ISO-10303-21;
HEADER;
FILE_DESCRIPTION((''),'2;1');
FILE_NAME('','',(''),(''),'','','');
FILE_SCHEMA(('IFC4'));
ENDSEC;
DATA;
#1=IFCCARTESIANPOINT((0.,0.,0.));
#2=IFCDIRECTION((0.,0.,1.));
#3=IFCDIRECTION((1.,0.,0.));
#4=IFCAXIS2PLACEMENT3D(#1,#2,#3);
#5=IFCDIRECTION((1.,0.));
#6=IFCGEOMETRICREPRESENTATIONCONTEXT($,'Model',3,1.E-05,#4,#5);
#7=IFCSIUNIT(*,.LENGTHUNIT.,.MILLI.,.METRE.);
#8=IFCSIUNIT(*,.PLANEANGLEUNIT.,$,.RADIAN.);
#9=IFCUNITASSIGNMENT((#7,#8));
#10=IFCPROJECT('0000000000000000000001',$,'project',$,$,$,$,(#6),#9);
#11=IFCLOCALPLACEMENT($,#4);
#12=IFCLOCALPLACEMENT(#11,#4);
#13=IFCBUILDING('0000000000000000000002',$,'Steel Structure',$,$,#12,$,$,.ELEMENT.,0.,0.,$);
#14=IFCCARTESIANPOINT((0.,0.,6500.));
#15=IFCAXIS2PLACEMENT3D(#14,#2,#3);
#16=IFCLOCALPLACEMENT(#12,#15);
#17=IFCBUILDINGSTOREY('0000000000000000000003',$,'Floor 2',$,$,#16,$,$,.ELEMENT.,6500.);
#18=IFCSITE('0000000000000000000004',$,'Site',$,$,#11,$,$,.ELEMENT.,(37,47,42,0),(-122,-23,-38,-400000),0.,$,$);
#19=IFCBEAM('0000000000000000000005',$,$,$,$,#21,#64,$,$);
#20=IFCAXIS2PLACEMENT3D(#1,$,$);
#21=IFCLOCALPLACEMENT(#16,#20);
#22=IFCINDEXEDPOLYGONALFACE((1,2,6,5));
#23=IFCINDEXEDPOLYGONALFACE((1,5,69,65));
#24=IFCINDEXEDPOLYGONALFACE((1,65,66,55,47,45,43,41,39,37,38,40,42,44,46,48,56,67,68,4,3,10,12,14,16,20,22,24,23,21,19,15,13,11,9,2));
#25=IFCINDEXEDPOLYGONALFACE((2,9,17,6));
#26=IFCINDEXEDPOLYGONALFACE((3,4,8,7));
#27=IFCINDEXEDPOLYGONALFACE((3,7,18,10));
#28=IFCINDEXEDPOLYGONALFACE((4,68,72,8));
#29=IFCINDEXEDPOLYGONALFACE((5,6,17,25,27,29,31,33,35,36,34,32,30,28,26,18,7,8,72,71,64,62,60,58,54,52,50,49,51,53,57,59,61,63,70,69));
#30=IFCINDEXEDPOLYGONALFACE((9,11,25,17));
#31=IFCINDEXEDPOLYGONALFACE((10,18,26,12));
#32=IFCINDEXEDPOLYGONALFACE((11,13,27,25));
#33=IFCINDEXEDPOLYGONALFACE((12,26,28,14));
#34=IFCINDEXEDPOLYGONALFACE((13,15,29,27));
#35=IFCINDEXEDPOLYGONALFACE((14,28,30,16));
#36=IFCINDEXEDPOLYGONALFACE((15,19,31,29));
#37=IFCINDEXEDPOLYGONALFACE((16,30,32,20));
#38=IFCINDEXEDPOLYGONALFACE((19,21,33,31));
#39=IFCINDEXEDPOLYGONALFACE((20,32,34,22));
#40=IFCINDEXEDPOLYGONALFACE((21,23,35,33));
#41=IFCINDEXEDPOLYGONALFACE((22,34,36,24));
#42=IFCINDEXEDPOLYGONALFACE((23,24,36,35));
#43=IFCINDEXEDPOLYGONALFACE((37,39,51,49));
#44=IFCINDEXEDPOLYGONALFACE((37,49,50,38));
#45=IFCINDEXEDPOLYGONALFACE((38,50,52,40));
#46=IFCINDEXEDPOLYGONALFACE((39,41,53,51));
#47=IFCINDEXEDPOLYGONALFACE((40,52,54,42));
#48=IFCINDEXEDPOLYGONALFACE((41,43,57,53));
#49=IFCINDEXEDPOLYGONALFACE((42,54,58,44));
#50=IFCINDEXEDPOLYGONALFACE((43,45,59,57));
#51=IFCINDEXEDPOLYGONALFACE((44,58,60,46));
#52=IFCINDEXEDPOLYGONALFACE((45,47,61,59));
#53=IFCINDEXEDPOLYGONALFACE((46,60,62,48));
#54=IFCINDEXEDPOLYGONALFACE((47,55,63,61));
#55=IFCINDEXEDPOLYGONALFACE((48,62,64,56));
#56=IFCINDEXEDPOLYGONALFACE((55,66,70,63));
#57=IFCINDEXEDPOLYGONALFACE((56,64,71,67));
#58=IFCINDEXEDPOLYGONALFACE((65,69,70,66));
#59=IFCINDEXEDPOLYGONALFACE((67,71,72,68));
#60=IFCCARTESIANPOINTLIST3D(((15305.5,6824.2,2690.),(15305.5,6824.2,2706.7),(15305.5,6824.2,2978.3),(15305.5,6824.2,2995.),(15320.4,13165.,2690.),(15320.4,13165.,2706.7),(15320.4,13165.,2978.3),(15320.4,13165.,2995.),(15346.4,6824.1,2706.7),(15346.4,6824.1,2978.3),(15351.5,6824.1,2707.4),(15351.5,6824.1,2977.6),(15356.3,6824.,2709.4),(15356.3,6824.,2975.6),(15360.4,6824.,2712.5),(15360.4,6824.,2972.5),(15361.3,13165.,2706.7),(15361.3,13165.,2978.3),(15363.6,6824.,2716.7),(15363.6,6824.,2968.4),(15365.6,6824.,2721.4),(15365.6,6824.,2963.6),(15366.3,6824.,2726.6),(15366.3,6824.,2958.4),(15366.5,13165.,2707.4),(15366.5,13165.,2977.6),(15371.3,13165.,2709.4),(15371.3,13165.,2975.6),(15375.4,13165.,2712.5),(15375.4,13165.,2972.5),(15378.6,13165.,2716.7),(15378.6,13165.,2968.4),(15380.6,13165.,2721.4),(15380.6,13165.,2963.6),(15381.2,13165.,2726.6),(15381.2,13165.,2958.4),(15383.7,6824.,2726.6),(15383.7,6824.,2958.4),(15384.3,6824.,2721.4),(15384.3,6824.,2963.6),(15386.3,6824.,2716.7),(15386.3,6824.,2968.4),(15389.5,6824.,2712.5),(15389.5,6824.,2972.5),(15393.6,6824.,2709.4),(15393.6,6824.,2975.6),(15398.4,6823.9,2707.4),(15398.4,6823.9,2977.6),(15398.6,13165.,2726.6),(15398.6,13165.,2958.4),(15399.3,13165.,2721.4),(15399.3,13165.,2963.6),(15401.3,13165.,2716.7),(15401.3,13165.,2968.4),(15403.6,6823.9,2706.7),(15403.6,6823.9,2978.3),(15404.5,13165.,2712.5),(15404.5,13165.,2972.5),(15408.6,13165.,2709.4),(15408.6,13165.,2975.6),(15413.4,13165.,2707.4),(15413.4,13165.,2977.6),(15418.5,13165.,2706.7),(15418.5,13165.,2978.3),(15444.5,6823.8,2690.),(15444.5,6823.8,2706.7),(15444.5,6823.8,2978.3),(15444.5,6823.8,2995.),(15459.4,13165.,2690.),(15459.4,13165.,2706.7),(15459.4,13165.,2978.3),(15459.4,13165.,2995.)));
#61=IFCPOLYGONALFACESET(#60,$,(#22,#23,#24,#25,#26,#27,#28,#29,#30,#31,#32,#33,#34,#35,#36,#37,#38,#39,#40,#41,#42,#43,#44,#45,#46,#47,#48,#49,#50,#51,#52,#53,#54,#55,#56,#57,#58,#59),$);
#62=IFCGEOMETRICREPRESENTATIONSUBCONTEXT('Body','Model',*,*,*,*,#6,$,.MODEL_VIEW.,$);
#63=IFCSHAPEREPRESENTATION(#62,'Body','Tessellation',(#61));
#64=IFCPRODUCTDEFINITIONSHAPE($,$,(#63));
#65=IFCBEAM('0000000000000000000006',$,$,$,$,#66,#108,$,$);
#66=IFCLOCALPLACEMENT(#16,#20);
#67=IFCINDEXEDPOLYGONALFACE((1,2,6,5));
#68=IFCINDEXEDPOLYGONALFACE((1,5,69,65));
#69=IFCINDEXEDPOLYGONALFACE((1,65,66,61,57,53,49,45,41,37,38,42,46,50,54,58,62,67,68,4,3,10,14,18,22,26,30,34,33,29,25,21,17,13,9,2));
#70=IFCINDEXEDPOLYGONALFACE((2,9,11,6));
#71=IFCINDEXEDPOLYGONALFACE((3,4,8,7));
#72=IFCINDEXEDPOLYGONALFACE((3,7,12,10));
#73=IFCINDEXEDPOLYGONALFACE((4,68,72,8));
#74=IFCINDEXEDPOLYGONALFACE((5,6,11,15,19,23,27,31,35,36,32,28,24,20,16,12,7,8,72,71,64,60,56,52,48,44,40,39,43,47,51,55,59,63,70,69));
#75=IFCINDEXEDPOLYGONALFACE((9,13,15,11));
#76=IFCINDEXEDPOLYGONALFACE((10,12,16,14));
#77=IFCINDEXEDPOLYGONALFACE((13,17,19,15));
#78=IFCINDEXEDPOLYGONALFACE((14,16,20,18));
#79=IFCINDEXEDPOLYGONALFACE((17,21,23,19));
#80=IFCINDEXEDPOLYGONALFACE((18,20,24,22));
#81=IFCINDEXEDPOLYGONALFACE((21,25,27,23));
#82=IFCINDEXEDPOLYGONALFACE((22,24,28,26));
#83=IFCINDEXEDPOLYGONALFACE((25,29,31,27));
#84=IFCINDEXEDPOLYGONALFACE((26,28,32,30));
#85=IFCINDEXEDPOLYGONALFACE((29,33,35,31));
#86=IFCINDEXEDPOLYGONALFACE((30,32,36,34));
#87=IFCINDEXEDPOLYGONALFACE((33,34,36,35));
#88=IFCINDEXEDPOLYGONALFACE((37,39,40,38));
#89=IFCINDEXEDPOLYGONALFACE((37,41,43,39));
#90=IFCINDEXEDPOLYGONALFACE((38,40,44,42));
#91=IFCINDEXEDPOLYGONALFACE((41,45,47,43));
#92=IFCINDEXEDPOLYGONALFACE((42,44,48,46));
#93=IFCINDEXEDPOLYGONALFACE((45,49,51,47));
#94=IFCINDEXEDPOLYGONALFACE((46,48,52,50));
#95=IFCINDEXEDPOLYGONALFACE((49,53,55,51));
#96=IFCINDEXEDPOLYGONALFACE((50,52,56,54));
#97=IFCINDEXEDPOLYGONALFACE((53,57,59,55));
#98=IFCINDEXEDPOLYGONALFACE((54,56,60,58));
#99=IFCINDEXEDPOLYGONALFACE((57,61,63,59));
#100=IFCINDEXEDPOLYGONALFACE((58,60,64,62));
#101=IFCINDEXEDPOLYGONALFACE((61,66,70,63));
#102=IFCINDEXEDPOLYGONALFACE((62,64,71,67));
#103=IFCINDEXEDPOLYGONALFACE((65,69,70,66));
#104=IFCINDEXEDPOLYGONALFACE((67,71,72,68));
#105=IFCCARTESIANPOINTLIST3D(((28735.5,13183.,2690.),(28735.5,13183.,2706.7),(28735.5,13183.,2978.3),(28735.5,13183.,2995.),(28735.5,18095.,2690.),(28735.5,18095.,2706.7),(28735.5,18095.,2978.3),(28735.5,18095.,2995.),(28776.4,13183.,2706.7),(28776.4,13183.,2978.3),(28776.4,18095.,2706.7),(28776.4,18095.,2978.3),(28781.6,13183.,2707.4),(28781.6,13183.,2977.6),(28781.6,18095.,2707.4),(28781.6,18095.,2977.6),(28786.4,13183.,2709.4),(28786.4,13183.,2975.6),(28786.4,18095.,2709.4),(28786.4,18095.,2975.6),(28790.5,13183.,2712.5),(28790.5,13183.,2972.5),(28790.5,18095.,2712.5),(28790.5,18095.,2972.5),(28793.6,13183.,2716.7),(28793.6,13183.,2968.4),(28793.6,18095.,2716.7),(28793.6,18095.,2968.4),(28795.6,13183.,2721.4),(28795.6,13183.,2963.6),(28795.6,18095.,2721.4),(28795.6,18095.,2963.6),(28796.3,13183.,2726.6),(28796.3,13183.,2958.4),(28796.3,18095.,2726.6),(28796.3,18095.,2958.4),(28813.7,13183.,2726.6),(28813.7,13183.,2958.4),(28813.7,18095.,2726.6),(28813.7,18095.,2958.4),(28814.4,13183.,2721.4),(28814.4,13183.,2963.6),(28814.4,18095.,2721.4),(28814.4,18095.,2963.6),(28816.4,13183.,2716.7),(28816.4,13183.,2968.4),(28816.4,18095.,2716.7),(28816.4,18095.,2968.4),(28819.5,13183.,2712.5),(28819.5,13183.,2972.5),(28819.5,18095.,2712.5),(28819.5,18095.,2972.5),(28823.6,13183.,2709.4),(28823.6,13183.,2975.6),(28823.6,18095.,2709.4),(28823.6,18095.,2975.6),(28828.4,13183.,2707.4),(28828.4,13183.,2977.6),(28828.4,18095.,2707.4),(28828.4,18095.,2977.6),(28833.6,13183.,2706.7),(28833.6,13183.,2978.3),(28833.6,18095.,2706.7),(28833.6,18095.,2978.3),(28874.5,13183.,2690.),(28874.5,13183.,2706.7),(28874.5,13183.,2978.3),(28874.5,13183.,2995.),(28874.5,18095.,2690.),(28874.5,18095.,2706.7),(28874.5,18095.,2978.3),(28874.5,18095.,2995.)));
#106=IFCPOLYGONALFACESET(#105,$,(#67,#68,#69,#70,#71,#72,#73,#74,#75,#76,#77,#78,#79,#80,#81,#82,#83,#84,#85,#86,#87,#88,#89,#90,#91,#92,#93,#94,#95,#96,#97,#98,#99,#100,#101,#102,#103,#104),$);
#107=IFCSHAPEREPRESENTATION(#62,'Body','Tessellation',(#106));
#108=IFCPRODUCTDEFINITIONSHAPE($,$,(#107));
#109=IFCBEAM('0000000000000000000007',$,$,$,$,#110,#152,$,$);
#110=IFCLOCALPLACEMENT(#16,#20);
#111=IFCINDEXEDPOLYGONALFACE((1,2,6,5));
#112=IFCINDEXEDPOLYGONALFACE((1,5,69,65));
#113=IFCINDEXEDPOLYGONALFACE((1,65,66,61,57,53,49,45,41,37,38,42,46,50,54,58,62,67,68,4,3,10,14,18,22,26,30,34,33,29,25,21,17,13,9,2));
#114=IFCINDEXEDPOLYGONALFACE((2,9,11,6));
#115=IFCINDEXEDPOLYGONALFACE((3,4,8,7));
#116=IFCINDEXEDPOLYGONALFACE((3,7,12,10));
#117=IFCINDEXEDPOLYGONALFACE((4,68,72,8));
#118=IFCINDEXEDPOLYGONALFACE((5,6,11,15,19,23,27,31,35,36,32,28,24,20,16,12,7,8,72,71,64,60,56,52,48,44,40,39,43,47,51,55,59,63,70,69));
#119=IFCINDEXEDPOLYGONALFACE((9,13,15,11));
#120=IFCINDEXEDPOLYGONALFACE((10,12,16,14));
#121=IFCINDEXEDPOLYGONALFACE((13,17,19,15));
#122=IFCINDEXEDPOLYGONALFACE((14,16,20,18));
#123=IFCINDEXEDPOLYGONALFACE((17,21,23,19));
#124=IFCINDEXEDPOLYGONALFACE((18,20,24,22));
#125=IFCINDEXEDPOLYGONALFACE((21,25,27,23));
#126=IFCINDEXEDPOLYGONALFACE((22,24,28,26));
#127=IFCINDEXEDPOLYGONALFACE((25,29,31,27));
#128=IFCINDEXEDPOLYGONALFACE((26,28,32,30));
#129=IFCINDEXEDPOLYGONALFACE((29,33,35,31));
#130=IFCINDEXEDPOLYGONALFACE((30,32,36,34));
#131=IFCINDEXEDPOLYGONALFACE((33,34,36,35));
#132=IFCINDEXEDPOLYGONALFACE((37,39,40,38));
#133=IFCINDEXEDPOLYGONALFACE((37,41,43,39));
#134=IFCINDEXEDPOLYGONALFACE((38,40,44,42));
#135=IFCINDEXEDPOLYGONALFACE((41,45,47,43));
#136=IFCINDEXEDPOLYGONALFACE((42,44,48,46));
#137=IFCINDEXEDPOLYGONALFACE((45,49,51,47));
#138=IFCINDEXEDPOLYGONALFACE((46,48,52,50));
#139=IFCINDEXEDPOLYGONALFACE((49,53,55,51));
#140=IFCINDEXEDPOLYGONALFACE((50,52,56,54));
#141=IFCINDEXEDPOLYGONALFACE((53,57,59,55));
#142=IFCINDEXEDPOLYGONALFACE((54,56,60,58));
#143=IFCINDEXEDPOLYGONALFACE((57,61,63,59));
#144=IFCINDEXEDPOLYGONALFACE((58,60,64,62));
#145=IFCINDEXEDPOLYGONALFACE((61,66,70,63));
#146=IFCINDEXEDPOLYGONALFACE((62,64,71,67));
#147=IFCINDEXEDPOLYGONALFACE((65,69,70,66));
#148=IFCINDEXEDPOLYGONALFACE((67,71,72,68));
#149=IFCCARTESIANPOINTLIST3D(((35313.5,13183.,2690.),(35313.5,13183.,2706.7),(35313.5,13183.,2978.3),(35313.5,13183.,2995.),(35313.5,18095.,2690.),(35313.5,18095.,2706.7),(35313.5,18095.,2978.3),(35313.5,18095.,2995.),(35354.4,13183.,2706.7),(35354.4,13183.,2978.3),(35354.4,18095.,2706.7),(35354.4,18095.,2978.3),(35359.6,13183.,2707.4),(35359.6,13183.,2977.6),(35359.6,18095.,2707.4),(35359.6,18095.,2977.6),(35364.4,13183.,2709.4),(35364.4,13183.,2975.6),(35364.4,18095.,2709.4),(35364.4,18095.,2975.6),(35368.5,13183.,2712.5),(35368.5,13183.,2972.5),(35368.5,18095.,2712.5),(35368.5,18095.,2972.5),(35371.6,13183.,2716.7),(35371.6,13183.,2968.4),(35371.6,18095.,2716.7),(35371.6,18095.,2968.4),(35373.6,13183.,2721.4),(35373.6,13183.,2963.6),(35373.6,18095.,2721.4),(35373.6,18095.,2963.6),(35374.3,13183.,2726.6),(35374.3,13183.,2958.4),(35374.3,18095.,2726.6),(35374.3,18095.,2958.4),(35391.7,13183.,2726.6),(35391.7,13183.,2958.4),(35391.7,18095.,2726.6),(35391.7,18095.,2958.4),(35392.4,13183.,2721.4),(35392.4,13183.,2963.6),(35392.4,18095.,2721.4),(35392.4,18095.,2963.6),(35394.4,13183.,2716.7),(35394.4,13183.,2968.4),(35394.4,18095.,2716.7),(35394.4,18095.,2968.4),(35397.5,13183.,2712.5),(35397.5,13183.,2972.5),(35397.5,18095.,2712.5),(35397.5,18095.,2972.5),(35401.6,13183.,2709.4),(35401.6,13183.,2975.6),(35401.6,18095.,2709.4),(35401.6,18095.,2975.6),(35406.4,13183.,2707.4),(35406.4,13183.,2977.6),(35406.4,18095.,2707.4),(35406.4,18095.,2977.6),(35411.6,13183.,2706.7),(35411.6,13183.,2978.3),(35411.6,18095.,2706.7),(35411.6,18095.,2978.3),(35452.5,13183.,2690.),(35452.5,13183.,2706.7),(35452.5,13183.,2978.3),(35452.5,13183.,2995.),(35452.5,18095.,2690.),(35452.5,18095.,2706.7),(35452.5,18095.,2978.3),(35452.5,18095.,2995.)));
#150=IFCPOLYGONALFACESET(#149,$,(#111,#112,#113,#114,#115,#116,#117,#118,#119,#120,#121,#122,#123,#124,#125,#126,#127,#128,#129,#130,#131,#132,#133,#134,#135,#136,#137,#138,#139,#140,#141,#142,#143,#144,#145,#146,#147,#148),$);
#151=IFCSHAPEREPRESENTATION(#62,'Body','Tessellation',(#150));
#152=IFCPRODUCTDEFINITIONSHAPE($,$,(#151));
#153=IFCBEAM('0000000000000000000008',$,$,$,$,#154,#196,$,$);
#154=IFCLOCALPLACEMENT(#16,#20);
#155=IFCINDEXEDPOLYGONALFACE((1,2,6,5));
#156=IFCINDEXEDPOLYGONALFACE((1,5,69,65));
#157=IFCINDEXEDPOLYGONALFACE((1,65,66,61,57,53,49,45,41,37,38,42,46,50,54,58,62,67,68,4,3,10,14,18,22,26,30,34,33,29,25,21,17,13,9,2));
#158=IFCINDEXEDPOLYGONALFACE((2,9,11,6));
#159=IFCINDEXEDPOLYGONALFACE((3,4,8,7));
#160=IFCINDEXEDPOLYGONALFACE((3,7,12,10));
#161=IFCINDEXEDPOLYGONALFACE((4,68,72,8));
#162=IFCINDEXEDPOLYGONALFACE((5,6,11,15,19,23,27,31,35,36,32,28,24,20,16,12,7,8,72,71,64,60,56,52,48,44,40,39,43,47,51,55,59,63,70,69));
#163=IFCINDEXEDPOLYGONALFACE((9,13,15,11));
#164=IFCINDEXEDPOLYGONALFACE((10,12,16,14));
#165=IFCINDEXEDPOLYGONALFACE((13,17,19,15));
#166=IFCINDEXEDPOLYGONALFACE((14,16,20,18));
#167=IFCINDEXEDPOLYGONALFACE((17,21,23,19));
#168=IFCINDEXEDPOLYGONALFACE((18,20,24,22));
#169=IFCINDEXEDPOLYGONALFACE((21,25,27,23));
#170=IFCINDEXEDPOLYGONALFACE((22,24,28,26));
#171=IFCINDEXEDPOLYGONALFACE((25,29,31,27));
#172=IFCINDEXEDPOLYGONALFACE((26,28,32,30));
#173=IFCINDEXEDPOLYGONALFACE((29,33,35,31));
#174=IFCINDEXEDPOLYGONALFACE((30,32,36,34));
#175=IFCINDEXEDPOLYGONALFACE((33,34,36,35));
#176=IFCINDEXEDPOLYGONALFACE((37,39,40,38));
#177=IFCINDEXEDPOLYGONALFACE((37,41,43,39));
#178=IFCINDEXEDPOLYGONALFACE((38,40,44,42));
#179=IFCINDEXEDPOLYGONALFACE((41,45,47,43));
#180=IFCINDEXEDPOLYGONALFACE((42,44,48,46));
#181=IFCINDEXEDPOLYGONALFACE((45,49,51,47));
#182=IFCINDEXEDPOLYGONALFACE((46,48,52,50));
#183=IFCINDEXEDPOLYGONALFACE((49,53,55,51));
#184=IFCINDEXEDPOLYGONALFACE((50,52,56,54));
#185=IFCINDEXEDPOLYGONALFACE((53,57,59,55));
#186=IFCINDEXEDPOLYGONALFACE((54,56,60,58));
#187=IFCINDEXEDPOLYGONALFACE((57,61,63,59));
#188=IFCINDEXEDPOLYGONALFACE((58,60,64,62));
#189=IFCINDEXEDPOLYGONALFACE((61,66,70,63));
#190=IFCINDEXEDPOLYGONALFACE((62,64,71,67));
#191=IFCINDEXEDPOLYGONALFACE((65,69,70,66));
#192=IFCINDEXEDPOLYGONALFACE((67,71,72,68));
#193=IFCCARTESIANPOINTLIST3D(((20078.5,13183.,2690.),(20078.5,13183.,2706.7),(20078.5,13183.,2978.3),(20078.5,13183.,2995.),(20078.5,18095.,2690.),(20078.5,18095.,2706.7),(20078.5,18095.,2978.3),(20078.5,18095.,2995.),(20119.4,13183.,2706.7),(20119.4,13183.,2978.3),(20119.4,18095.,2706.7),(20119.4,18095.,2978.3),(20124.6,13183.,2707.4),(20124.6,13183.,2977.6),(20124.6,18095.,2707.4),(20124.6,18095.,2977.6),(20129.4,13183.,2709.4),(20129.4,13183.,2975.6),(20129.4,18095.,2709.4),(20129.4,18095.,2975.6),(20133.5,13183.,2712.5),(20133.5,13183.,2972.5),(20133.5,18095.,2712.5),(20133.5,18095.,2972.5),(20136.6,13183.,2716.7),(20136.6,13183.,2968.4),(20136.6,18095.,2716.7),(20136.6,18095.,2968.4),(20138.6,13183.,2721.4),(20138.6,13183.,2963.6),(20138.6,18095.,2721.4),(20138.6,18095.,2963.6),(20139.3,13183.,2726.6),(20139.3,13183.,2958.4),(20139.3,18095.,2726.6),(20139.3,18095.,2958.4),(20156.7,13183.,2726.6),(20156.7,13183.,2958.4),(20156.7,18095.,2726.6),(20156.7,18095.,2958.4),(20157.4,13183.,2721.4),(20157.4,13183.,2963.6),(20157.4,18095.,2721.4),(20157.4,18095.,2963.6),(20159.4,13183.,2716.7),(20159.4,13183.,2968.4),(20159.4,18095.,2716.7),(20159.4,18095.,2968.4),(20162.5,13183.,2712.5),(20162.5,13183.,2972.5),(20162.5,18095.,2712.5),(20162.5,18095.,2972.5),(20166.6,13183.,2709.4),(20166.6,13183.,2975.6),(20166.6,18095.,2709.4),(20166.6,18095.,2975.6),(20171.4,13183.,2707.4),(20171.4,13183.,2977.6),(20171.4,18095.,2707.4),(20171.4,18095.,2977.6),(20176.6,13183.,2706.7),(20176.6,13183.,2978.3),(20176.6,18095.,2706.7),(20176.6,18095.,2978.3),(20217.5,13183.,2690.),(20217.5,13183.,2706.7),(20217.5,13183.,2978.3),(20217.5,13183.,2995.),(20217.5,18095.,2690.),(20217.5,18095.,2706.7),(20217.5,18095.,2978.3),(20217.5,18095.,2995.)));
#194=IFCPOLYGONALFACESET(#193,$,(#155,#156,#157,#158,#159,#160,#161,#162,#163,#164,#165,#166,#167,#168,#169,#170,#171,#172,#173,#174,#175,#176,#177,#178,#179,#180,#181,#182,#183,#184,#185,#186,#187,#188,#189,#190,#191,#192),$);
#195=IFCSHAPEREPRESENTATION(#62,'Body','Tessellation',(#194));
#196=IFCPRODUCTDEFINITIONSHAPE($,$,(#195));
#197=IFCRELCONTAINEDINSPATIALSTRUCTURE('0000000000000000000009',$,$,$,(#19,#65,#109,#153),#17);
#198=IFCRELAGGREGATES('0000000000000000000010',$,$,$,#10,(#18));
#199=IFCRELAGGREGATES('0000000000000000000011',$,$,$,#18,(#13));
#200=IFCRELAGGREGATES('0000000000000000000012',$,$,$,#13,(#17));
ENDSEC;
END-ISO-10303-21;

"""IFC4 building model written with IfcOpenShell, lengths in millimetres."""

from ifc_helpers import new_model, si_unit, direction, frame, origin_with_axes, origin_2d_with_axis, place, context, subcontext, project, spatial, polyline, i_section, extrude, clip, bounded_halfspace, element, save


model = new_model("IFC4")

# Units and contexts
model_context = context("Model", 3, precision=1e-05, world=origin_with_axes(), true_north=direction((1.0, 0.0)))
body_context = subcontext(model_context, "Body", "Model", "MODEL_VIEW")
ifc_project = project(units=[si_unit("LENGTHUNIT", "METRE", prefix="MILLI"), si_unit("PLANEANGLEUNIT", "RADIAN")], contexts=[model_context])

# Site, building, storey
site_placement = place(None, origin_with_axes())
site = spatial("IfcSite", under=ifc_project, at=site_placement, Name="Site", CompositionType="ELEMENT", RefLatitude=(37, 47, 42, 0), RefLongitude=(-122, -23, -38, -400000), RefElevation=0.0)
building_placement = place(site_placement, origin_with_axes())
building = spatial("IfcBuilding", under=site, at=building_placement, Name="Steel Structure", CompositionType="ELEMENT", ElevationOfRefHeight=0.0, ElevationOfTerrain=0.0)
storey_placement = place(building_placement, frame((0.0, 0.0, 6500.0), z_axis=(0.0, 0.0, 1.0), x_axis=(1.0, 0.0, 0.0)))
storey = spatial("IfcBuildingStorey", under=building, at=storey_placement, Name="Floor 2", CompositionType="ELEMENT", Elevation=6500.0)

# Beams
beam_1_placement = place(storey_placement, frame((15389.9, 13165.2, 2690.0), z_axis=(-0.002362, -0.999997, 0.0), x_axis=(0.999997, -0.002362, 0.0)))
element("IfcBeam", 1, at=beam_1_placement, inside=storey, context=body_context, shape_type="Clipping", body=[
    clip(extrude(i_section(OverallWidth=139.0, OverallDepth=305.0, WebThickness=17.4, FlangeThickness=16.7, FilletRadius=19.9, at=origin_2d_with_axis()), frame((0.0, 152.5, 0.0), z_axis=(0.0, 0.0, 1.0), x_axis=(1.0, 0.0, 0.0)), (0.0, 0.0, 1.0), 6341.2), bounded_halfspace(frame((-15389.9, -9190.0, 36.5), z_axis=(-0.002362, 0.0, -0.999997), x_axis=(-0.999997, 0.0, 0.002362)), False, frame((0.0, 152.5, 0.0), z_axis=(0.0, 0.0, 1.0), x_axis=(1.0, 0.0, 0.0)), polyline([(69.5, 152.5), (69.5, 135.8), (28.6, 135.8), (8.7, 115.9), (8.7, -115.9), (28.6, -135.8), (69.5, -135.8), (69.5, -152.5), (-69.5, -152.5), (-69.5, -135.8), (-28.6, -135.8), (-8.7, -115.9), (-8.7, 115.9), (-28.6, 135.8), (-69.5, 135.8), (-69.5, 152.5), (69.5, 152.5)]))),
])
beam_2_placement = place(storey_placement, frame((28805.0, 13183.0, 2690.0), z_axis=(0.0, 1.0, 0.0), x_axis=(-1.0, 0.0, 0.0)))
element("IfcBeam", 2, at=beam_2_placement, inside=storey, context=body_context, shape_type="SweptSolid", body=[
    extrude(i_section(OverallWidth=139.0, OverallDepth=305.0, WebThickness=17.4, FlangeThickness=16.7, FilletRadius=19.9, at=origin_2d_with_axis()), frame((0.0, 152.5, 0.0), z_axis=(0.0, 0.0, 1.0), x_axis=(1.0, 0.0, 0.0)), (0.0, 0.0, 1.0), 4912.0),
])
for number, where, z_axis, x_axis in (
    (3, (35383.0, 13183.0, 2690.0), (0.0, 1.0, 0.0), (-1.0, 0.0, 0.0)),
    (4, (20148.0, 13183.0, 2690.0), (0.0, 1.0, 0.0), (-1.0, 0.0, 0.0)),
):
    element("IfcBeam", number, at=place(storey_placement, frame(where, z_axis=z_axis, x_axis=x_axis)), inside=storey, context=body_context, shape_type="SweptSolid", body=[
        extrude(i_section(OverallWidth=139.0, OverallDepth=305.0, WebThickness=17.4, FlangeThickness=16.7, FilletRadius=19.9, at=origin_2d_with_axis()), frame((0.0, 152.5, 0.0), z_axis=(0.0, 0.0, 1.0), x_axis=(1.0, 0.0, 0.0)), (0.0, 0.0, 1.0), 4912.0),
    ])

save(model, "model.ifc")
